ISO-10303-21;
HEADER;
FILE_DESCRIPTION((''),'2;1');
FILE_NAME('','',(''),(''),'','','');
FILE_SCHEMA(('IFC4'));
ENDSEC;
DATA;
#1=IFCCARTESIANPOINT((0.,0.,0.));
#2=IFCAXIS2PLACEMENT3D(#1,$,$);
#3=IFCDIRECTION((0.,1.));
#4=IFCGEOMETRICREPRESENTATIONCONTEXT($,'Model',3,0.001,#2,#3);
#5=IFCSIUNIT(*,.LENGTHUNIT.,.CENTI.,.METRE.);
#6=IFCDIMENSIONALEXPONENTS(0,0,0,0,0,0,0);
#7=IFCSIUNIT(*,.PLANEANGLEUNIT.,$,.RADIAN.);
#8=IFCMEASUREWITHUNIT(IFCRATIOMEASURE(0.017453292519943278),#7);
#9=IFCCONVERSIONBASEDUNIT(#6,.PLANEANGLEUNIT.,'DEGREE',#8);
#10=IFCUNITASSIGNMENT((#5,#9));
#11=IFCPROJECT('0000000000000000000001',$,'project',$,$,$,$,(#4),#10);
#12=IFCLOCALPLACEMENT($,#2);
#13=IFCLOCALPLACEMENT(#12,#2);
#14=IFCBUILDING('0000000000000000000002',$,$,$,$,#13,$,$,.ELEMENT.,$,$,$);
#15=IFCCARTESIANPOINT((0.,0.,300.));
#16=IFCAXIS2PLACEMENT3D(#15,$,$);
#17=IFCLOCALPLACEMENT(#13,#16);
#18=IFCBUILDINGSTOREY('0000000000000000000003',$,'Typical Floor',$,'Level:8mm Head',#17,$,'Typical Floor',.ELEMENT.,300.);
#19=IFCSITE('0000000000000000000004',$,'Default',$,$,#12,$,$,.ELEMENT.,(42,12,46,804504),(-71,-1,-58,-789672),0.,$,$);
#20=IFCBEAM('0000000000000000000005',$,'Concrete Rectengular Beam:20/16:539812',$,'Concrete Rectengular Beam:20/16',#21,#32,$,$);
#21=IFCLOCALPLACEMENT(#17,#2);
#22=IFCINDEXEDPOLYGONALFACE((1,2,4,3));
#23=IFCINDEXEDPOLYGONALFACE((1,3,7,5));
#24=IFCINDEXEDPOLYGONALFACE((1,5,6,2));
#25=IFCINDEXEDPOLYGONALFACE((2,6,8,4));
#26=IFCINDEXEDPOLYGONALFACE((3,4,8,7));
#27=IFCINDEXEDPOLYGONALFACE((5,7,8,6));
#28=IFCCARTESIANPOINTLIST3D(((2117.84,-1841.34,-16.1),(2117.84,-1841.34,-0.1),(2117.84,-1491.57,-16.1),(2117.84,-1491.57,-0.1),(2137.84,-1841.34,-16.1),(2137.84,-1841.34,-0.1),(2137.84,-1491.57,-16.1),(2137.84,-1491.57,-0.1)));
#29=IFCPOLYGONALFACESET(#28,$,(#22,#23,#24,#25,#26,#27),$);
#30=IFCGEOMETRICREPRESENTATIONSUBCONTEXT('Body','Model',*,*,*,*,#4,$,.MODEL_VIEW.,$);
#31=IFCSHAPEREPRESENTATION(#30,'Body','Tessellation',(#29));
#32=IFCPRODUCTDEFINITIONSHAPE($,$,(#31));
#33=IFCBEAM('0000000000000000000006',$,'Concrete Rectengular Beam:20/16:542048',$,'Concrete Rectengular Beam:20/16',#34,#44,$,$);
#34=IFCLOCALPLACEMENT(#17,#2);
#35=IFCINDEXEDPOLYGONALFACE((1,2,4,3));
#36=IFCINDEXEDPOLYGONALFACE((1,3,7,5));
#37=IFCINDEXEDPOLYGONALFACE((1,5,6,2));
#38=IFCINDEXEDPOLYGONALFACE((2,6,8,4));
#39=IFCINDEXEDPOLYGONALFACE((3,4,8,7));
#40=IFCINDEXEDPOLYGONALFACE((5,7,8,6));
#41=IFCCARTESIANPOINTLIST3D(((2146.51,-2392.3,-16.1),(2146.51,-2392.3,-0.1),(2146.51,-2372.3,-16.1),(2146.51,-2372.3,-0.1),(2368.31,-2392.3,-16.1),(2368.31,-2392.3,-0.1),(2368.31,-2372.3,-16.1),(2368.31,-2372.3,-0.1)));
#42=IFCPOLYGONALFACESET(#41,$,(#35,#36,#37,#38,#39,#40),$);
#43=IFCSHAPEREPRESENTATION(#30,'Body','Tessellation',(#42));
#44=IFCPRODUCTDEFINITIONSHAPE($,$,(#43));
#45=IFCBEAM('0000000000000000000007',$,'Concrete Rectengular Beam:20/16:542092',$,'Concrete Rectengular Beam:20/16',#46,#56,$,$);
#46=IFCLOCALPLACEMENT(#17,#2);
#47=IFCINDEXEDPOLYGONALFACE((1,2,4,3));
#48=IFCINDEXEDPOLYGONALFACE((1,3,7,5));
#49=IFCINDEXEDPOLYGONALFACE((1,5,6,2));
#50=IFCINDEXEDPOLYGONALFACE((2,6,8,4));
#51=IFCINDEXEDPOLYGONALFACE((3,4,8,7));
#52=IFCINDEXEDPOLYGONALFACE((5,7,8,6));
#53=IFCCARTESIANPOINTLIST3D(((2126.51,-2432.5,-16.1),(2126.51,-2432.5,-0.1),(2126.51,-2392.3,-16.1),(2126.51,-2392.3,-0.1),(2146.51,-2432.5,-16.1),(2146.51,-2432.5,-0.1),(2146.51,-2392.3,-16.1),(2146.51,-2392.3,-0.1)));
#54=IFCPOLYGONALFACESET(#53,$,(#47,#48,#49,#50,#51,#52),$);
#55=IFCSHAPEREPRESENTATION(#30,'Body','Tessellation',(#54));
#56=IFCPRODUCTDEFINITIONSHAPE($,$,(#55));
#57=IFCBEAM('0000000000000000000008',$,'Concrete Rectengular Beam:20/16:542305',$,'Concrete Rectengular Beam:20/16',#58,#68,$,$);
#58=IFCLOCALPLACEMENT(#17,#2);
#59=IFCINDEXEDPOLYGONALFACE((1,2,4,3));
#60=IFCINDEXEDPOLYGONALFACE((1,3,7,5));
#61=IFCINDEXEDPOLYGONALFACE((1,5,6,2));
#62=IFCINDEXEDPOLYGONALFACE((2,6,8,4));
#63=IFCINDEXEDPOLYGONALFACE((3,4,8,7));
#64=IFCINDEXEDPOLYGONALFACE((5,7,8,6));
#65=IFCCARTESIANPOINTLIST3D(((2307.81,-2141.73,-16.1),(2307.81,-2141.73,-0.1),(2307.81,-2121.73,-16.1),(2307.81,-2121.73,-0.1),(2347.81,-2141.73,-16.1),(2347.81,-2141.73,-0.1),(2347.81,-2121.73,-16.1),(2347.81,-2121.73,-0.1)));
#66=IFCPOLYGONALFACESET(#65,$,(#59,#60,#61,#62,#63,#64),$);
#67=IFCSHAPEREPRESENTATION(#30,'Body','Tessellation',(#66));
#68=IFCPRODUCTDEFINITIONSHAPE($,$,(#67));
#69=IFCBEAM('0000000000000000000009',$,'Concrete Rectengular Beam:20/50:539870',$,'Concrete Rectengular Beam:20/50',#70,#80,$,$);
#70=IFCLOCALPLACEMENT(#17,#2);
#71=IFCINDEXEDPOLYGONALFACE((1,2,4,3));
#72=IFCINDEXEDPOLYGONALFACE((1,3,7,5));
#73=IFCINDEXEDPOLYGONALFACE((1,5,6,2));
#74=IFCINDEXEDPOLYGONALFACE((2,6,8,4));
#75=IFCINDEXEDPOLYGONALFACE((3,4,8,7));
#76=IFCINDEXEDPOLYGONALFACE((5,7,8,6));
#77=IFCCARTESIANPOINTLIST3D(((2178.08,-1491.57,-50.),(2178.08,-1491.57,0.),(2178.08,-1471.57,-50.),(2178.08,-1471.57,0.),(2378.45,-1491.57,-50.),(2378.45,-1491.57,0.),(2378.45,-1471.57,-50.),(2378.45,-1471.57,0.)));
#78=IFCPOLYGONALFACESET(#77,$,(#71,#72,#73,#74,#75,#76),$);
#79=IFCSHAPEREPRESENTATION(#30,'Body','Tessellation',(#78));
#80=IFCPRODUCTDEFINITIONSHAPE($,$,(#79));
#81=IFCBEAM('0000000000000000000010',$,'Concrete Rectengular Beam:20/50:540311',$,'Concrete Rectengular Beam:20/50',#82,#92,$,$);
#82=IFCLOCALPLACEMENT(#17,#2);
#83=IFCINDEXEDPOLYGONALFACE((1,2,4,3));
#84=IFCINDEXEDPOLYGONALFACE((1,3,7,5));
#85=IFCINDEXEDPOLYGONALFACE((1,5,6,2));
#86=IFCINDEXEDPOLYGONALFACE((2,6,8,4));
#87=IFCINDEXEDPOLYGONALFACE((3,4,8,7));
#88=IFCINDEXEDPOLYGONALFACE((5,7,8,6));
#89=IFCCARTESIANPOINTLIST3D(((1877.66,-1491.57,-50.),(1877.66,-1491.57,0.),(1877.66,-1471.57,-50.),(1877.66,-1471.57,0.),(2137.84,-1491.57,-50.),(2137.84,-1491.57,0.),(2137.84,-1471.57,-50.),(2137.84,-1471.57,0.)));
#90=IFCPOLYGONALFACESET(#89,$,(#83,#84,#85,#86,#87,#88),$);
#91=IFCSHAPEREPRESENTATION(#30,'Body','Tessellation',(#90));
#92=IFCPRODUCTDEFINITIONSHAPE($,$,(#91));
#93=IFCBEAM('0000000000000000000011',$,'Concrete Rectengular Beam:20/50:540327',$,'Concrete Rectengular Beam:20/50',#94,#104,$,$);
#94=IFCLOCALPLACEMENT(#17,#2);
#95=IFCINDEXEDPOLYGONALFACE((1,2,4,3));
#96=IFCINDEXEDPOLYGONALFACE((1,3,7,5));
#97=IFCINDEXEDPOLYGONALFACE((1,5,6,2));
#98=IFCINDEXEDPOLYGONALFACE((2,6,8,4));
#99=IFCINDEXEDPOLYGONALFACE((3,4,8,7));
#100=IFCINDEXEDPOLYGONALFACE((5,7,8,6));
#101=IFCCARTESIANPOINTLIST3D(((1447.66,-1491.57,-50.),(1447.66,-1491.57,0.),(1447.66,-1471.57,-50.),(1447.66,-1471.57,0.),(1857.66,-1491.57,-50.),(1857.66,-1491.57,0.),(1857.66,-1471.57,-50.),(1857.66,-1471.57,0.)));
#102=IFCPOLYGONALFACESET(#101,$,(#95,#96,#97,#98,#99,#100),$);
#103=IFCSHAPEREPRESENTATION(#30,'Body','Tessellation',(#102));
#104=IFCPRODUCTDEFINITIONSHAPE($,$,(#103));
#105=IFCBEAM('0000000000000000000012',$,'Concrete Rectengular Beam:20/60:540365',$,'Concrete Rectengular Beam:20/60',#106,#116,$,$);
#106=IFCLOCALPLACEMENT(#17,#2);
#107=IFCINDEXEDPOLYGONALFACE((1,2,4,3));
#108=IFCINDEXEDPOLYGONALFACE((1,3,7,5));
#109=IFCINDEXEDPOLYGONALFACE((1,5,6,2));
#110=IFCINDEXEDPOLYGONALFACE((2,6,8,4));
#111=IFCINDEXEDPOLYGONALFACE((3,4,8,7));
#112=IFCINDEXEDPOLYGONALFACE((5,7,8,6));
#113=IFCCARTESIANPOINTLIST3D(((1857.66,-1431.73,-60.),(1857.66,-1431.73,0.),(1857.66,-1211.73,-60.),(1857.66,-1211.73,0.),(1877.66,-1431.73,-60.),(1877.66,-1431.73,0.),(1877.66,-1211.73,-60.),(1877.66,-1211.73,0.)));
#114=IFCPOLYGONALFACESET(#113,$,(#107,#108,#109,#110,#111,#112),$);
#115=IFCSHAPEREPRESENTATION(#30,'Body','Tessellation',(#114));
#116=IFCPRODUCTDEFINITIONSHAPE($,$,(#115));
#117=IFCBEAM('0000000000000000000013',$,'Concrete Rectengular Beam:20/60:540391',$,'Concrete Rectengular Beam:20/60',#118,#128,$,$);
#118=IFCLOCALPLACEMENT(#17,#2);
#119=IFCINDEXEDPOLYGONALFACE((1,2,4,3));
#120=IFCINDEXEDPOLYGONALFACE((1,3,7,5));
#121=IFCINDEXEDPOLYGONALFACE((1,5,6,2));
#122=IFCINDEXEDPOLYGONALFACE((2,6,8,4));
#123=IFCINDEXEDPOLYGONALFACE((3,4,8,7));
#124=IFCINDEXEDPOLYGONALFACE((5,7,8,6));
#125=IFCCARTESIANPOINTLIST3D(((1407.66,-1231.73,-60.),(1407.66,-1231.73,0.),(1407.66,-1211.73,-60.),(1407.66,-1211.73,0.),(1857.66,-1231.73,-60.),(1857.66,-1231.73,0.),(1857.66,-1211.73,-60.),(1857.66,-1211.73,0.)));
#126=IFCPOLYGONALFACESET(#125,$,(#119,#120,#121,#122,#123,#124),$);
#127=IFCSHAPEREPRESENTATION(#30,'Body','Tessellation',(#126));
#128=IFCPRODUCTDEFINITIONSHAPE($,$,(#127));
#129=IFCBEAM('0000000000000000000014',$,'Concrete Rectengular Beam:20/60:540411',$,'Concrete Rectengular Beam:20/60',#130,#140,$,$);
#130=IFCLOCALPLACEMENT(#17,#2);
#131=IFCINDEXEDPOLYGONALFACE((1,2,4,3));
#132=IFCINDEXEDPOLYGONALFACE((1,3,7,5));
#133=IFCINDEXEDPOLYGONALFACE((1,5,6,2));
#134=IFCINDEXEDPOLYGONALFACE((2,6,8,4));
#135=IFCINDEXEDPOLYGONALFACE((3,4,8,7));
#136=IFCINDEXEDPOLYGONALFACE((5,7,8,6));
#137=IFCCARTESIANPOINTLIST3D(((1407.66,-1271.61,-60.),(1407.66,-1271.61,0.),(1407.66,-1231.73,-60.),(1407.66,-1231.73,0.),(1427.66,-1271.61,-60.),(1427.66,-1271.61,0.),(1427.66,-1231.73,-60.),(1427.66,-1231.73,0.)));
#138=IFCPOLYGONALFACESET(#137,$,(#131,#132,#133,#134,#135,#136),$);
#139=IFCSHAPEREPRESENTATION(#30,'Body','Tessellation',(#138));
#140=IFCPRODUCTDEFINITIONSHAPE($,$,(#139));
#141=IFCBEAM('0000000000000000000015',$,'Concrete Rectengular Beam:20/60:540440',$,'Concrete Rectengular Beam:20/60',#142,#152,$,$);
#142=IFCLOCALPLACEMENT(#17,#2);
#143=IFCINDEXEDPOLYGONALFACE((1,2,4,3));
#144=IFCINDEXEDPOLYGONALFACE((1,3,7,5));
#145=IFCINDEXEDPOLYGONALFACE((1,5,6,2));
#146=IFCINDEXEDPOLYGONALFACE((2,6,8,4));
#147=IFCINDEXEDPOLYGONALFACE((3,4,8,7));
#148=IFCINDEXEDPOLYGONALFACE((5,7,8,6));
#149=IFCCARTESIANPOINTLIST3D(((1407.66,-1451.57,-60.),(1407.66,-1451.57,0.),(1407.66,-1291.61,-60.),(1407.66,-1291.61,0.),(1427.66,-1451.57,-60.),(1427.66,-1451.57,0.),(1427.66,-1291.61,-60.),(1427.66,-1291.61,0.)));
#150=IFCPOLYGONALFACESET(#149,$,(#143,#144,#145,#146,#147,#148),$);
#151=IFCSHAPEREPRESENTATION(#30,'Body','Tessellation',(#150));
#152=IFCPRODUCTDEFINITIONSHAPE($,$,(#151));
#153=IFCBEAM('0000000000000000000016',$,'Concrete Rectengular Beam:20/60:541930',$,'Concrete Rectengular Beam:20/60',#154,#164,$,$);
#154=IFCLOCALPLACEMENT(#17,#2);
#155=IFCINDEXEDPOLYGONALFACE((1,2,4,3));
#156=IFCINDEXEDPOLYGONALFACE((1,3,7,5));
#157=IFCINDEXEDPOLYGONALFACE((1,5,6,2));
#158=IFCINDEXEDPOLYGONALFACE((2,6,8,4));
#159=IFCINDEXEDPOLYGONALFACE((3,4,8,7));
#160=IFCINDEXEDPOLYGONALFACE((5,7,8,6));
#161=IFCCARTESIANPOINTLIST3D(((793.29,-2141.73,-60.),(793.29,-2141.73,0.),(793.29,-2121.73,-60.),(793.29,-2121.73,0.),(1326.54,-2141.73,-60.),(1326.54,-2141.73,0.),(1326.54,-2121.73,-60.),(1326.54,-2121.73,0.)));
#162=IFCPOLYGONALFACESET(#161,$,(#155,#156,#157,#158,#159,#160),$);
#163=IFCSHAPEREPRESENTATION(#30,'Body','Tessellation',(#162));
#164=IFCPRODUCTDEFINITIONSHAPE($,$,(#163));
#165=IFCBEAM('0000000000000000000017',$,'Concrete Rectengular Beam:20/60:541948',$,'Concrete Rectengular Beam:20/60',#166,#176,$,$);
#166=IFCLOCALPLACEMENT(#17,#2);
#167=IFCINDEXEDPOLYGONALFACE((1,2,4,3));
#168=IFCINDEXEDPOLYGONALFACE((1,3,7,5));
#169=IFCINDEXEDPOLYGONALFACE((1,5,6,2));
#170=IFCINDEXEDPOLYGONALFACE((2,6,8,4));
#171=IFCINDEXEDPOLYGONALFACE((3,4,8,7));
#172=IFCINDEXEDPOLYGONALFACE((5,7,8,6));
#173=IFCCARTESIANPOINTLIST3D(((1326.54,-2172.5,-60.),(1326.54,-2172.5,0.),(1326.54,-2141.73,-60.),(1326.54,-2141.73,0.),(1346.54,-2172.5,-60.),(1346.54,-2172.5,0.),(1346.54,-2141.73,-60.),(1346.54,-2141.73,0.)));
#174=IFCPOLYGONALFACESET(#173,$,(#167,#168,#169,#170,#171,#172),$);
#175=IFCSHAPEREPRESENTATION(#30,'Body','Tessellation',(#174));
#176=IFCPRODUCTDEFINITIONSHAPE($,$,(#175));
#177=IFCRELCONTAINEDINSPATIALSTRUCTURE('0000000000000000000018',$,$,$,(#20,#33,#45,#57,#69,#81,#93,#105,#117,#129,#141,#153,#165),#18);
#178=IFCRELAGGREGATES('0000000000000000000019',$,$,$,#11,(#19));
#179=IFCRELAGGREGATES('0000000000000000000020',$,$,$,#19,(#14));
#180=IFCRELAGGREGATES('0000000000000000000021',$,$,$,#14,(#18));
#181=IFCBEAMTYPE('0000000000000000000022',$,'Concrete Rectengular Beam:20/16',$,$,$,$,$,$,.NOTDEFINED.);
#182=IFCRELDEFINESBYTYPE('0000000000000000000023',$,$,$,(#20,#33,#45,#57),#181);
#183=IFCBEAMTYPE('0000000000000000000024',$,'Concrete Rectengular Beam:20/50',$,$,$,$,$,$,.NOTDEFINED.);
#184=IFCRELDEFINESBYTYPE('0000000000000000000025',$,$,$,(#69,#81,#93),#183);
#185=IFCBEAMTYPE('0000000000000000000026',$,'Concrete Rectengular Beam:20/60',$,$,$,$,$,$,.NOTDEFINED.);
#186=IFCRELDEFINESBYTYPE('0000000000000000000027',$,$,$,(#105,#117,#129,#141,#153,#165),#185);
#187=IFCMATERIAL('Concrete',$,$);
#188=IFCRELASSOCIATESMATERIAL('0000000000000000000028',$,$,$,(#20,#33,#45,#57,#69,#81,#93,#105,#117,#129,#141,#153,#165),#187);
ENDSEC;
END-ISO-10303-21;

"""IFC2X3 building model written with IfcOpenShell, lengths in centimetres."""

from ifc_helpers import new_model, entity, si_unit, converted_unit, direction, frame, frame_2d, origin, place, context, subcontext, project, spatial, rectangle, extrude, material, type_object, element, save


model = new_model("IFC2X3")

# Units and contexts
model_context = context("Model", 3, precision=0.001, world=origin(), true_north=direction((0.0, 1.0)))
body_context = subcontext(model_context, "Body", "Model", "MODEL_VIEW")
ifc_project = project(units=[si_unit("LENGTHUNIT", "METRE", prefix="CENTI"), converted_unit("PLANEANGLEUNIT", "DEGREE", entity("IfcRatioMeasure", 0.017453292519943278), si_unit("PLANEANGLEUNIT", "RADIAN"), dimensions=[0, 0, 0, 0, 0, 0, 0])], contexts=[model_context])

# Site, building, storey
site_placement = place(None, origin())
site = spatial("IfcSite", under=ifc_project, at=site_placement, Name="Default", CompositionType="ELEMENT", RefLatitude=(42, 12, 46, 804504), RefLongitude=(-71, -1, -58, -789672), RefElevation=0.0)
building_placement = place(site_placement, origin())
building = spatial("IfcBuilding", under=site, at=building_placement, CompositionType="ELEMENT")
storey_placement = place(building_placement, frame((0.0, 0.0, 300.0)))
storey = spatial("IfcBuildingStorey", under=building, at=storey_placement, Name="Typical Floor", ObjectType="Level:8mm Head", LongName="Typical Floor", CompositionType="ELEMENT", Elevation=300.0)

# Beams
ifc_material = material(Name="Concrete")
beam_type_1 = type_object("IfcBeamType", Name="Concrete Rectengular Beam:20/16", PredefinedType="NOTDEFINED")
beam_1_placement = place(storey_placement, frame((2127.84, -1861.34, 0.0), z_axis=(0.0, 0.0, 1.0), x_axis=(0.0, 1.0, 0.0)))
element("IfcBeam", 1, at=beam_1_placement, inside=storey, type_object=beam_type_1, material=ifc_material, Name="Concrete Rectengular Beam:20/16:539812", ObjectType="Concrete Rectengular Beam:20/16", context=body_context, shape_type="SweptSolid", body=[
    extrude(rectangle(XDim=16.0, YDim=20.0, at=frame_2d((0.0, 0.0), x_axis=(1.0, 0.0))), frame((20.0, 0.0, -8.1), z_axis=(1.0, 0.0, 0.0), x_axis=(0.0, 0.0, -1.0)), (0.0, 0.0, 1.0), 349.76),
])
beam_2_placement = place(storey_placement, frame((2136.51, -2382.3, 0.0)))
element("IfcBeam", 2, at=beam_2_placement, inside=storey, type_object=beam_type_1, material=ifc_material, Name="Concrete Rectengular Beam:20/16:542048", ObjectType="Concrete Rectengular Beam:20/16", context=body_context, shape_type="SweptSolid", body=[
    extrude(rectangle(XDim=16.0, YDim=20.0, at=frame_2d((0.0, 0.0), x_axis=(1.0, 0.0))), frame((10.0, 0.0, -8.1), z_axis=(1.0, 0.0, 0.0), x_axis=(0.0, 0.0, -1.0)), (0.0, 0.0, 1.0), 221.8),
])
beam_3_placement = place(storey_placement, frame((2136.51, -2382.3, 0.0), z_axis=(0.0, 0.0, 1.0), x_axis=(0.0, -1.0, 0.0)))
element("IfcBeam", 3, at=beam_3_placement, inside=storey, type_object=beam_type_1, material=ifc_material, Name="Concrete Rectengular Beam:20/16:542092", ObjectType="Concrete Rectengular Beam:20/16", context=body_context, shape_type="SweptSolid", body=[
    extrude(rectangle(XDim=16.0, YDim=20.0, at=frame_2d((0.0, 0.0), x_axis=(1.0, 0.0))), frame((10.0, 0.0, -8.1), z_axis=(1.0, 0.0, 0.0), x_axis=(0.0, 0.0, -1.0)), (0.0, 0.0, 1.0), 40.21),
])
beam_4_placement = place(storey_placement, frame((2357.81, -2131.73, 0.0), z_axis=(0.0, 0.0, 1.0), x_axis=(-1.0, 0.0, 0.0)))
element("IfcBeam", 4, at=beam_4_placement, inside=storey, type_object=beam_type_1, material=ifc_material, Name="Concrete Rectengular Beam:20/16:542305", ObjectType="Concrete Rectengular Beam:20/16", context=body_context, shape_type="SweptSolid", body=[
    extrude(rectangle(XDim=16.0, YDim=20.0, at=frame_2d((0.0, 0.0), x_axis=(1.0, 0.0))), frame((10.0, 0.0, -8.1), z_axis=(1.0, 0.0, 0.0), x_axis=(0.0, 0.0, -1.0)), (0.0, 0.0, 1.0), 40.0),
])
beam_type_2 = type_object("IfcBeamType", Name="Concrete Rectengular Beam:20/50", PredefinedType="NOTDEFINED")
beam_5_placement = place(storey_placement, frame((2158.08, -1481.57, 0.0)))
element("IfcBeam", 5, at=beam_5_placement, inside=storey, type_object=beam_type_2, material=ifc_material, Name="Concrete Rectengular Beam:20/50:539870", ObjectType="Concrete Rectengular Beam:20/50", context=body_context, shape_type="SweptSolid", body=[
    extrude(rectangle(XDim=50.0, YDim=20.0, at=frame_2d((0.0, 0.0), x_axis=(1.0, 0.0))), frame((20.0, 0.0, -25.0), z_axis=(1.0, 0.0, 0.0), x_axis=(0.0, 0.0, -1.0)), (0.0, 0.0, 1.0), 200.37),
])
beam_6_placement = place(storey_placement, frame((2127.84, -1481.57, 0.0), z_axis=(0.0, 0.0, 1.0), x_axis=(-1.0, 0.0, 0.0)))
element("IfcBeam", 6, at=beam_6_placement, inside=storey, type_object=beam_type_2, material=ifc_material, Name="Concrete Rectengular Beam:20/50:540311", ObjectType="Concrete Rectengular Beam:20/50", context=body_context, shape_type="SweptSolid", body=[
    extrude(rectangle(XDim=50.0, YDim=20.0, at=frame_2d((0.0, 0.0), x_axis=(1.0, 0.0))), frame((-10.0, 0.0, -25.0), z_axis=(1.0, 0.0, 0.0), x_axis=(0.0, 0.0, -1.0)), (0.0, 0.0, 1.0), 260.18),
])
beam_7_placement = place(storey_placement, frame((1867.66, -1481.57, 0.0), z_axis=(0.0, 0.0, 1.0), x_axis=(-1.0, 0.0, 0.0)))
element("IfcBeam", 7, at=beam_7_placement, inside=storey, type_object=beam_type_2, material=ifc_material, Name="Concrete Rectengular Beam:20/50:540327", ObjectType="Concrete Rectengular Beam:20/50", context=body_context, shape_type="SweptSolid", body=[
    extrude(rectangle(XDim=50.0, YDim=20.0, at=frame_2d((0.0, 0.0), x_axis=(1.0, 0.0))), frame((10.0, 0.0, -25.0), z_axis=(1.0, 0.0, 0.0), x_axis=(0.0, 0.0, -1.0)), (0.0, 0.0, 1.0), 410.0),
])
beam_type_3 = type_object("IfcBeamType", Name="Concrete Rectengular Beam:20/60", PredefinedType="NOTDEFINED")
beam_8_placement = place(storey_placement, frame((1867.66, -1461.73, 0.0), z_axis=(0.0, 0.0, 1.0), x_axis=(0.0, 1.0, 0.0)))
element("IfcBeam", 8, at=beam_8_placement, inside=storey, type_object=beam_type_3, material=ifc_material, Name="Concrete Rectengular Beam:20/60:540365", ObjectType="Concrete Rectengular Beam:20/60", context=body_context, shape_type="SweptSolid", body=[
    extrude(rectangle(XDim=60.0, YDim=20.0, at=frame_2d((0.0, 0.0), x_axis=(1.0, 0.0))), frame((30.0, 0.0, -30.0), z_axis=(1.0, 0.0, 0.0), x_axis=(0.0, 0.0, -1.0)), (0.0, 0.0, 1.0), 220.0),
])
beam_9_placement = place(storey_placement, frame((1867.66, -1221.73, 0.0), z_axis=(0.0, 0.0, 1.0), x_axis=(-1.0, 0.0, 0.0)))
element("IfcBeam", 9, at=beam_9_placement, inside=storey, type_object=beam_type_3, material=ifc_material, Name="Concrete Rectengular Beam:20/60:540391", ObjectType="Concrete Rectengular Beam:20/60", context=body_context, shape_type="SweptSolid", body=[
    extrude(rectangle(XDim=60.0, YDim=20.0, at=frame_2d((0.0, 0.0), x_axis=(1.0, 0.0))), frame((10.0, 0.0, -30.0), z_axis=(1.0, 0.0, 0.0), x_axis=(0.0, 0.0, -1.0)), (0.0, 0.0, 1.0), 450.0),
])
beam_10_placement = place(storey_placement, frame((1417.66, -1221.73, 0.0), z_axis=(0.0, 0.0, 1.0), x_axis=(0.0, -1.0, 0.0)))
element("IfcBeam", 10, at=beam_10_placement, inside=storey, type_object=beam_type_3, material=ifc_material, Name="Concrete Rectengular Beam:20/60:540411", ObjectType="Concrete Rectengular Beam:20/60", context=body_context, shape_type="SweptSolid", body=[
    extrude(rectangle(XDim=60.0, YDim=20.0, at=frame_2d((0.0, 0.0), x_axis=(1.0, 0.0))), frame((10.0, 0.0, -30.0), z_axis=(1.0, 0.0, 0.0), x_axis=(0.0, 0.0, -1.0)), (0.0, 0.0, 1.0), 39.88),
])
beam_11_placement = place(storey_placement, frame((1417.66, -1281.61, 0.0), z_axis=(0.0, 0.0, 1.0), x_axis=(0.0, -1.0, 0.0)))
element("IfcBeam", 11, at=beam_11_placement, inside=storey, type_object=beam_type_3, material=ifc_material, Name="Concrete Rectengular Beam:20/60:540440", ObjectType="Concrete Rectengular Beam:20/60", context=body_context, shape_type="SweptSolid", body=[
    extrude(rectangle(XDim=60.0, YDim=20.0, at=frame_2d((0.0, 0.0), x_axis=(1.0, 0.0))), frame((10.0, 0.0, -30.0), z_axis=(1.0, 0.0, 0.0), x_axis=(0.0, 0.0, -1.0)), (0.0, 0.0, 1.0), 159.96),
])
beam_12_placement = place(storey_placement, frame((783.29, -2131.73, 0.0)))
element("IfcBeam", 12, at=beam_12_placement, inside=storey, type_object=beam_type_3, material=ifc_material, Name="Concrete Rectengular Beam:20/60:541930", ObjectType="Concrete Rectengular Beam:20/60", context=body_context, shape_type="SweptSolid", body=[
    extrude(rectangle(XDim=60.0, YDim=20.0, at=frame_2d((0.0, 0.0), x_axis=(1.0, 0.0))), frame((10.0, 0.0, -30.0), z_axis=(1.0, 0.0, 0.0), x_axis=(0.0, 0.0, -1.0)), (0.0, 0.0, 1.0), 533.26),
])
beam_13_placement = place(storey_placement, frame((1336.54, -2131.73, 0.0), z_axis=(0.0, 0.0, 1.0), x_axis=(0.0, -1.0, 0.0)))
element("IfcBeam", 13, at=beam_13_placement, inside=storey, type_object=beam_type_3, material=ifc_material, Name="Concrete Rectengular Beam:20/60:541948", ObjectType="Concrete Rectengular Beam:20/60", context=body_context, shape_type="SweptSolid", body=[
    extrude(rectangle(XDim=60.0, YDim=20.0, at=frame_2d((0.0, 0.0), x_axis=(1.0, 0.0))), frame((10.0, 0.0, -30.0), z_axis=(1.0, 0.0, 0.0), x_axis=(0.0, 0.0, -1.0)), (0.0, 0.0, 1.0), 30.77),
])

save(model, "model.ifc")
